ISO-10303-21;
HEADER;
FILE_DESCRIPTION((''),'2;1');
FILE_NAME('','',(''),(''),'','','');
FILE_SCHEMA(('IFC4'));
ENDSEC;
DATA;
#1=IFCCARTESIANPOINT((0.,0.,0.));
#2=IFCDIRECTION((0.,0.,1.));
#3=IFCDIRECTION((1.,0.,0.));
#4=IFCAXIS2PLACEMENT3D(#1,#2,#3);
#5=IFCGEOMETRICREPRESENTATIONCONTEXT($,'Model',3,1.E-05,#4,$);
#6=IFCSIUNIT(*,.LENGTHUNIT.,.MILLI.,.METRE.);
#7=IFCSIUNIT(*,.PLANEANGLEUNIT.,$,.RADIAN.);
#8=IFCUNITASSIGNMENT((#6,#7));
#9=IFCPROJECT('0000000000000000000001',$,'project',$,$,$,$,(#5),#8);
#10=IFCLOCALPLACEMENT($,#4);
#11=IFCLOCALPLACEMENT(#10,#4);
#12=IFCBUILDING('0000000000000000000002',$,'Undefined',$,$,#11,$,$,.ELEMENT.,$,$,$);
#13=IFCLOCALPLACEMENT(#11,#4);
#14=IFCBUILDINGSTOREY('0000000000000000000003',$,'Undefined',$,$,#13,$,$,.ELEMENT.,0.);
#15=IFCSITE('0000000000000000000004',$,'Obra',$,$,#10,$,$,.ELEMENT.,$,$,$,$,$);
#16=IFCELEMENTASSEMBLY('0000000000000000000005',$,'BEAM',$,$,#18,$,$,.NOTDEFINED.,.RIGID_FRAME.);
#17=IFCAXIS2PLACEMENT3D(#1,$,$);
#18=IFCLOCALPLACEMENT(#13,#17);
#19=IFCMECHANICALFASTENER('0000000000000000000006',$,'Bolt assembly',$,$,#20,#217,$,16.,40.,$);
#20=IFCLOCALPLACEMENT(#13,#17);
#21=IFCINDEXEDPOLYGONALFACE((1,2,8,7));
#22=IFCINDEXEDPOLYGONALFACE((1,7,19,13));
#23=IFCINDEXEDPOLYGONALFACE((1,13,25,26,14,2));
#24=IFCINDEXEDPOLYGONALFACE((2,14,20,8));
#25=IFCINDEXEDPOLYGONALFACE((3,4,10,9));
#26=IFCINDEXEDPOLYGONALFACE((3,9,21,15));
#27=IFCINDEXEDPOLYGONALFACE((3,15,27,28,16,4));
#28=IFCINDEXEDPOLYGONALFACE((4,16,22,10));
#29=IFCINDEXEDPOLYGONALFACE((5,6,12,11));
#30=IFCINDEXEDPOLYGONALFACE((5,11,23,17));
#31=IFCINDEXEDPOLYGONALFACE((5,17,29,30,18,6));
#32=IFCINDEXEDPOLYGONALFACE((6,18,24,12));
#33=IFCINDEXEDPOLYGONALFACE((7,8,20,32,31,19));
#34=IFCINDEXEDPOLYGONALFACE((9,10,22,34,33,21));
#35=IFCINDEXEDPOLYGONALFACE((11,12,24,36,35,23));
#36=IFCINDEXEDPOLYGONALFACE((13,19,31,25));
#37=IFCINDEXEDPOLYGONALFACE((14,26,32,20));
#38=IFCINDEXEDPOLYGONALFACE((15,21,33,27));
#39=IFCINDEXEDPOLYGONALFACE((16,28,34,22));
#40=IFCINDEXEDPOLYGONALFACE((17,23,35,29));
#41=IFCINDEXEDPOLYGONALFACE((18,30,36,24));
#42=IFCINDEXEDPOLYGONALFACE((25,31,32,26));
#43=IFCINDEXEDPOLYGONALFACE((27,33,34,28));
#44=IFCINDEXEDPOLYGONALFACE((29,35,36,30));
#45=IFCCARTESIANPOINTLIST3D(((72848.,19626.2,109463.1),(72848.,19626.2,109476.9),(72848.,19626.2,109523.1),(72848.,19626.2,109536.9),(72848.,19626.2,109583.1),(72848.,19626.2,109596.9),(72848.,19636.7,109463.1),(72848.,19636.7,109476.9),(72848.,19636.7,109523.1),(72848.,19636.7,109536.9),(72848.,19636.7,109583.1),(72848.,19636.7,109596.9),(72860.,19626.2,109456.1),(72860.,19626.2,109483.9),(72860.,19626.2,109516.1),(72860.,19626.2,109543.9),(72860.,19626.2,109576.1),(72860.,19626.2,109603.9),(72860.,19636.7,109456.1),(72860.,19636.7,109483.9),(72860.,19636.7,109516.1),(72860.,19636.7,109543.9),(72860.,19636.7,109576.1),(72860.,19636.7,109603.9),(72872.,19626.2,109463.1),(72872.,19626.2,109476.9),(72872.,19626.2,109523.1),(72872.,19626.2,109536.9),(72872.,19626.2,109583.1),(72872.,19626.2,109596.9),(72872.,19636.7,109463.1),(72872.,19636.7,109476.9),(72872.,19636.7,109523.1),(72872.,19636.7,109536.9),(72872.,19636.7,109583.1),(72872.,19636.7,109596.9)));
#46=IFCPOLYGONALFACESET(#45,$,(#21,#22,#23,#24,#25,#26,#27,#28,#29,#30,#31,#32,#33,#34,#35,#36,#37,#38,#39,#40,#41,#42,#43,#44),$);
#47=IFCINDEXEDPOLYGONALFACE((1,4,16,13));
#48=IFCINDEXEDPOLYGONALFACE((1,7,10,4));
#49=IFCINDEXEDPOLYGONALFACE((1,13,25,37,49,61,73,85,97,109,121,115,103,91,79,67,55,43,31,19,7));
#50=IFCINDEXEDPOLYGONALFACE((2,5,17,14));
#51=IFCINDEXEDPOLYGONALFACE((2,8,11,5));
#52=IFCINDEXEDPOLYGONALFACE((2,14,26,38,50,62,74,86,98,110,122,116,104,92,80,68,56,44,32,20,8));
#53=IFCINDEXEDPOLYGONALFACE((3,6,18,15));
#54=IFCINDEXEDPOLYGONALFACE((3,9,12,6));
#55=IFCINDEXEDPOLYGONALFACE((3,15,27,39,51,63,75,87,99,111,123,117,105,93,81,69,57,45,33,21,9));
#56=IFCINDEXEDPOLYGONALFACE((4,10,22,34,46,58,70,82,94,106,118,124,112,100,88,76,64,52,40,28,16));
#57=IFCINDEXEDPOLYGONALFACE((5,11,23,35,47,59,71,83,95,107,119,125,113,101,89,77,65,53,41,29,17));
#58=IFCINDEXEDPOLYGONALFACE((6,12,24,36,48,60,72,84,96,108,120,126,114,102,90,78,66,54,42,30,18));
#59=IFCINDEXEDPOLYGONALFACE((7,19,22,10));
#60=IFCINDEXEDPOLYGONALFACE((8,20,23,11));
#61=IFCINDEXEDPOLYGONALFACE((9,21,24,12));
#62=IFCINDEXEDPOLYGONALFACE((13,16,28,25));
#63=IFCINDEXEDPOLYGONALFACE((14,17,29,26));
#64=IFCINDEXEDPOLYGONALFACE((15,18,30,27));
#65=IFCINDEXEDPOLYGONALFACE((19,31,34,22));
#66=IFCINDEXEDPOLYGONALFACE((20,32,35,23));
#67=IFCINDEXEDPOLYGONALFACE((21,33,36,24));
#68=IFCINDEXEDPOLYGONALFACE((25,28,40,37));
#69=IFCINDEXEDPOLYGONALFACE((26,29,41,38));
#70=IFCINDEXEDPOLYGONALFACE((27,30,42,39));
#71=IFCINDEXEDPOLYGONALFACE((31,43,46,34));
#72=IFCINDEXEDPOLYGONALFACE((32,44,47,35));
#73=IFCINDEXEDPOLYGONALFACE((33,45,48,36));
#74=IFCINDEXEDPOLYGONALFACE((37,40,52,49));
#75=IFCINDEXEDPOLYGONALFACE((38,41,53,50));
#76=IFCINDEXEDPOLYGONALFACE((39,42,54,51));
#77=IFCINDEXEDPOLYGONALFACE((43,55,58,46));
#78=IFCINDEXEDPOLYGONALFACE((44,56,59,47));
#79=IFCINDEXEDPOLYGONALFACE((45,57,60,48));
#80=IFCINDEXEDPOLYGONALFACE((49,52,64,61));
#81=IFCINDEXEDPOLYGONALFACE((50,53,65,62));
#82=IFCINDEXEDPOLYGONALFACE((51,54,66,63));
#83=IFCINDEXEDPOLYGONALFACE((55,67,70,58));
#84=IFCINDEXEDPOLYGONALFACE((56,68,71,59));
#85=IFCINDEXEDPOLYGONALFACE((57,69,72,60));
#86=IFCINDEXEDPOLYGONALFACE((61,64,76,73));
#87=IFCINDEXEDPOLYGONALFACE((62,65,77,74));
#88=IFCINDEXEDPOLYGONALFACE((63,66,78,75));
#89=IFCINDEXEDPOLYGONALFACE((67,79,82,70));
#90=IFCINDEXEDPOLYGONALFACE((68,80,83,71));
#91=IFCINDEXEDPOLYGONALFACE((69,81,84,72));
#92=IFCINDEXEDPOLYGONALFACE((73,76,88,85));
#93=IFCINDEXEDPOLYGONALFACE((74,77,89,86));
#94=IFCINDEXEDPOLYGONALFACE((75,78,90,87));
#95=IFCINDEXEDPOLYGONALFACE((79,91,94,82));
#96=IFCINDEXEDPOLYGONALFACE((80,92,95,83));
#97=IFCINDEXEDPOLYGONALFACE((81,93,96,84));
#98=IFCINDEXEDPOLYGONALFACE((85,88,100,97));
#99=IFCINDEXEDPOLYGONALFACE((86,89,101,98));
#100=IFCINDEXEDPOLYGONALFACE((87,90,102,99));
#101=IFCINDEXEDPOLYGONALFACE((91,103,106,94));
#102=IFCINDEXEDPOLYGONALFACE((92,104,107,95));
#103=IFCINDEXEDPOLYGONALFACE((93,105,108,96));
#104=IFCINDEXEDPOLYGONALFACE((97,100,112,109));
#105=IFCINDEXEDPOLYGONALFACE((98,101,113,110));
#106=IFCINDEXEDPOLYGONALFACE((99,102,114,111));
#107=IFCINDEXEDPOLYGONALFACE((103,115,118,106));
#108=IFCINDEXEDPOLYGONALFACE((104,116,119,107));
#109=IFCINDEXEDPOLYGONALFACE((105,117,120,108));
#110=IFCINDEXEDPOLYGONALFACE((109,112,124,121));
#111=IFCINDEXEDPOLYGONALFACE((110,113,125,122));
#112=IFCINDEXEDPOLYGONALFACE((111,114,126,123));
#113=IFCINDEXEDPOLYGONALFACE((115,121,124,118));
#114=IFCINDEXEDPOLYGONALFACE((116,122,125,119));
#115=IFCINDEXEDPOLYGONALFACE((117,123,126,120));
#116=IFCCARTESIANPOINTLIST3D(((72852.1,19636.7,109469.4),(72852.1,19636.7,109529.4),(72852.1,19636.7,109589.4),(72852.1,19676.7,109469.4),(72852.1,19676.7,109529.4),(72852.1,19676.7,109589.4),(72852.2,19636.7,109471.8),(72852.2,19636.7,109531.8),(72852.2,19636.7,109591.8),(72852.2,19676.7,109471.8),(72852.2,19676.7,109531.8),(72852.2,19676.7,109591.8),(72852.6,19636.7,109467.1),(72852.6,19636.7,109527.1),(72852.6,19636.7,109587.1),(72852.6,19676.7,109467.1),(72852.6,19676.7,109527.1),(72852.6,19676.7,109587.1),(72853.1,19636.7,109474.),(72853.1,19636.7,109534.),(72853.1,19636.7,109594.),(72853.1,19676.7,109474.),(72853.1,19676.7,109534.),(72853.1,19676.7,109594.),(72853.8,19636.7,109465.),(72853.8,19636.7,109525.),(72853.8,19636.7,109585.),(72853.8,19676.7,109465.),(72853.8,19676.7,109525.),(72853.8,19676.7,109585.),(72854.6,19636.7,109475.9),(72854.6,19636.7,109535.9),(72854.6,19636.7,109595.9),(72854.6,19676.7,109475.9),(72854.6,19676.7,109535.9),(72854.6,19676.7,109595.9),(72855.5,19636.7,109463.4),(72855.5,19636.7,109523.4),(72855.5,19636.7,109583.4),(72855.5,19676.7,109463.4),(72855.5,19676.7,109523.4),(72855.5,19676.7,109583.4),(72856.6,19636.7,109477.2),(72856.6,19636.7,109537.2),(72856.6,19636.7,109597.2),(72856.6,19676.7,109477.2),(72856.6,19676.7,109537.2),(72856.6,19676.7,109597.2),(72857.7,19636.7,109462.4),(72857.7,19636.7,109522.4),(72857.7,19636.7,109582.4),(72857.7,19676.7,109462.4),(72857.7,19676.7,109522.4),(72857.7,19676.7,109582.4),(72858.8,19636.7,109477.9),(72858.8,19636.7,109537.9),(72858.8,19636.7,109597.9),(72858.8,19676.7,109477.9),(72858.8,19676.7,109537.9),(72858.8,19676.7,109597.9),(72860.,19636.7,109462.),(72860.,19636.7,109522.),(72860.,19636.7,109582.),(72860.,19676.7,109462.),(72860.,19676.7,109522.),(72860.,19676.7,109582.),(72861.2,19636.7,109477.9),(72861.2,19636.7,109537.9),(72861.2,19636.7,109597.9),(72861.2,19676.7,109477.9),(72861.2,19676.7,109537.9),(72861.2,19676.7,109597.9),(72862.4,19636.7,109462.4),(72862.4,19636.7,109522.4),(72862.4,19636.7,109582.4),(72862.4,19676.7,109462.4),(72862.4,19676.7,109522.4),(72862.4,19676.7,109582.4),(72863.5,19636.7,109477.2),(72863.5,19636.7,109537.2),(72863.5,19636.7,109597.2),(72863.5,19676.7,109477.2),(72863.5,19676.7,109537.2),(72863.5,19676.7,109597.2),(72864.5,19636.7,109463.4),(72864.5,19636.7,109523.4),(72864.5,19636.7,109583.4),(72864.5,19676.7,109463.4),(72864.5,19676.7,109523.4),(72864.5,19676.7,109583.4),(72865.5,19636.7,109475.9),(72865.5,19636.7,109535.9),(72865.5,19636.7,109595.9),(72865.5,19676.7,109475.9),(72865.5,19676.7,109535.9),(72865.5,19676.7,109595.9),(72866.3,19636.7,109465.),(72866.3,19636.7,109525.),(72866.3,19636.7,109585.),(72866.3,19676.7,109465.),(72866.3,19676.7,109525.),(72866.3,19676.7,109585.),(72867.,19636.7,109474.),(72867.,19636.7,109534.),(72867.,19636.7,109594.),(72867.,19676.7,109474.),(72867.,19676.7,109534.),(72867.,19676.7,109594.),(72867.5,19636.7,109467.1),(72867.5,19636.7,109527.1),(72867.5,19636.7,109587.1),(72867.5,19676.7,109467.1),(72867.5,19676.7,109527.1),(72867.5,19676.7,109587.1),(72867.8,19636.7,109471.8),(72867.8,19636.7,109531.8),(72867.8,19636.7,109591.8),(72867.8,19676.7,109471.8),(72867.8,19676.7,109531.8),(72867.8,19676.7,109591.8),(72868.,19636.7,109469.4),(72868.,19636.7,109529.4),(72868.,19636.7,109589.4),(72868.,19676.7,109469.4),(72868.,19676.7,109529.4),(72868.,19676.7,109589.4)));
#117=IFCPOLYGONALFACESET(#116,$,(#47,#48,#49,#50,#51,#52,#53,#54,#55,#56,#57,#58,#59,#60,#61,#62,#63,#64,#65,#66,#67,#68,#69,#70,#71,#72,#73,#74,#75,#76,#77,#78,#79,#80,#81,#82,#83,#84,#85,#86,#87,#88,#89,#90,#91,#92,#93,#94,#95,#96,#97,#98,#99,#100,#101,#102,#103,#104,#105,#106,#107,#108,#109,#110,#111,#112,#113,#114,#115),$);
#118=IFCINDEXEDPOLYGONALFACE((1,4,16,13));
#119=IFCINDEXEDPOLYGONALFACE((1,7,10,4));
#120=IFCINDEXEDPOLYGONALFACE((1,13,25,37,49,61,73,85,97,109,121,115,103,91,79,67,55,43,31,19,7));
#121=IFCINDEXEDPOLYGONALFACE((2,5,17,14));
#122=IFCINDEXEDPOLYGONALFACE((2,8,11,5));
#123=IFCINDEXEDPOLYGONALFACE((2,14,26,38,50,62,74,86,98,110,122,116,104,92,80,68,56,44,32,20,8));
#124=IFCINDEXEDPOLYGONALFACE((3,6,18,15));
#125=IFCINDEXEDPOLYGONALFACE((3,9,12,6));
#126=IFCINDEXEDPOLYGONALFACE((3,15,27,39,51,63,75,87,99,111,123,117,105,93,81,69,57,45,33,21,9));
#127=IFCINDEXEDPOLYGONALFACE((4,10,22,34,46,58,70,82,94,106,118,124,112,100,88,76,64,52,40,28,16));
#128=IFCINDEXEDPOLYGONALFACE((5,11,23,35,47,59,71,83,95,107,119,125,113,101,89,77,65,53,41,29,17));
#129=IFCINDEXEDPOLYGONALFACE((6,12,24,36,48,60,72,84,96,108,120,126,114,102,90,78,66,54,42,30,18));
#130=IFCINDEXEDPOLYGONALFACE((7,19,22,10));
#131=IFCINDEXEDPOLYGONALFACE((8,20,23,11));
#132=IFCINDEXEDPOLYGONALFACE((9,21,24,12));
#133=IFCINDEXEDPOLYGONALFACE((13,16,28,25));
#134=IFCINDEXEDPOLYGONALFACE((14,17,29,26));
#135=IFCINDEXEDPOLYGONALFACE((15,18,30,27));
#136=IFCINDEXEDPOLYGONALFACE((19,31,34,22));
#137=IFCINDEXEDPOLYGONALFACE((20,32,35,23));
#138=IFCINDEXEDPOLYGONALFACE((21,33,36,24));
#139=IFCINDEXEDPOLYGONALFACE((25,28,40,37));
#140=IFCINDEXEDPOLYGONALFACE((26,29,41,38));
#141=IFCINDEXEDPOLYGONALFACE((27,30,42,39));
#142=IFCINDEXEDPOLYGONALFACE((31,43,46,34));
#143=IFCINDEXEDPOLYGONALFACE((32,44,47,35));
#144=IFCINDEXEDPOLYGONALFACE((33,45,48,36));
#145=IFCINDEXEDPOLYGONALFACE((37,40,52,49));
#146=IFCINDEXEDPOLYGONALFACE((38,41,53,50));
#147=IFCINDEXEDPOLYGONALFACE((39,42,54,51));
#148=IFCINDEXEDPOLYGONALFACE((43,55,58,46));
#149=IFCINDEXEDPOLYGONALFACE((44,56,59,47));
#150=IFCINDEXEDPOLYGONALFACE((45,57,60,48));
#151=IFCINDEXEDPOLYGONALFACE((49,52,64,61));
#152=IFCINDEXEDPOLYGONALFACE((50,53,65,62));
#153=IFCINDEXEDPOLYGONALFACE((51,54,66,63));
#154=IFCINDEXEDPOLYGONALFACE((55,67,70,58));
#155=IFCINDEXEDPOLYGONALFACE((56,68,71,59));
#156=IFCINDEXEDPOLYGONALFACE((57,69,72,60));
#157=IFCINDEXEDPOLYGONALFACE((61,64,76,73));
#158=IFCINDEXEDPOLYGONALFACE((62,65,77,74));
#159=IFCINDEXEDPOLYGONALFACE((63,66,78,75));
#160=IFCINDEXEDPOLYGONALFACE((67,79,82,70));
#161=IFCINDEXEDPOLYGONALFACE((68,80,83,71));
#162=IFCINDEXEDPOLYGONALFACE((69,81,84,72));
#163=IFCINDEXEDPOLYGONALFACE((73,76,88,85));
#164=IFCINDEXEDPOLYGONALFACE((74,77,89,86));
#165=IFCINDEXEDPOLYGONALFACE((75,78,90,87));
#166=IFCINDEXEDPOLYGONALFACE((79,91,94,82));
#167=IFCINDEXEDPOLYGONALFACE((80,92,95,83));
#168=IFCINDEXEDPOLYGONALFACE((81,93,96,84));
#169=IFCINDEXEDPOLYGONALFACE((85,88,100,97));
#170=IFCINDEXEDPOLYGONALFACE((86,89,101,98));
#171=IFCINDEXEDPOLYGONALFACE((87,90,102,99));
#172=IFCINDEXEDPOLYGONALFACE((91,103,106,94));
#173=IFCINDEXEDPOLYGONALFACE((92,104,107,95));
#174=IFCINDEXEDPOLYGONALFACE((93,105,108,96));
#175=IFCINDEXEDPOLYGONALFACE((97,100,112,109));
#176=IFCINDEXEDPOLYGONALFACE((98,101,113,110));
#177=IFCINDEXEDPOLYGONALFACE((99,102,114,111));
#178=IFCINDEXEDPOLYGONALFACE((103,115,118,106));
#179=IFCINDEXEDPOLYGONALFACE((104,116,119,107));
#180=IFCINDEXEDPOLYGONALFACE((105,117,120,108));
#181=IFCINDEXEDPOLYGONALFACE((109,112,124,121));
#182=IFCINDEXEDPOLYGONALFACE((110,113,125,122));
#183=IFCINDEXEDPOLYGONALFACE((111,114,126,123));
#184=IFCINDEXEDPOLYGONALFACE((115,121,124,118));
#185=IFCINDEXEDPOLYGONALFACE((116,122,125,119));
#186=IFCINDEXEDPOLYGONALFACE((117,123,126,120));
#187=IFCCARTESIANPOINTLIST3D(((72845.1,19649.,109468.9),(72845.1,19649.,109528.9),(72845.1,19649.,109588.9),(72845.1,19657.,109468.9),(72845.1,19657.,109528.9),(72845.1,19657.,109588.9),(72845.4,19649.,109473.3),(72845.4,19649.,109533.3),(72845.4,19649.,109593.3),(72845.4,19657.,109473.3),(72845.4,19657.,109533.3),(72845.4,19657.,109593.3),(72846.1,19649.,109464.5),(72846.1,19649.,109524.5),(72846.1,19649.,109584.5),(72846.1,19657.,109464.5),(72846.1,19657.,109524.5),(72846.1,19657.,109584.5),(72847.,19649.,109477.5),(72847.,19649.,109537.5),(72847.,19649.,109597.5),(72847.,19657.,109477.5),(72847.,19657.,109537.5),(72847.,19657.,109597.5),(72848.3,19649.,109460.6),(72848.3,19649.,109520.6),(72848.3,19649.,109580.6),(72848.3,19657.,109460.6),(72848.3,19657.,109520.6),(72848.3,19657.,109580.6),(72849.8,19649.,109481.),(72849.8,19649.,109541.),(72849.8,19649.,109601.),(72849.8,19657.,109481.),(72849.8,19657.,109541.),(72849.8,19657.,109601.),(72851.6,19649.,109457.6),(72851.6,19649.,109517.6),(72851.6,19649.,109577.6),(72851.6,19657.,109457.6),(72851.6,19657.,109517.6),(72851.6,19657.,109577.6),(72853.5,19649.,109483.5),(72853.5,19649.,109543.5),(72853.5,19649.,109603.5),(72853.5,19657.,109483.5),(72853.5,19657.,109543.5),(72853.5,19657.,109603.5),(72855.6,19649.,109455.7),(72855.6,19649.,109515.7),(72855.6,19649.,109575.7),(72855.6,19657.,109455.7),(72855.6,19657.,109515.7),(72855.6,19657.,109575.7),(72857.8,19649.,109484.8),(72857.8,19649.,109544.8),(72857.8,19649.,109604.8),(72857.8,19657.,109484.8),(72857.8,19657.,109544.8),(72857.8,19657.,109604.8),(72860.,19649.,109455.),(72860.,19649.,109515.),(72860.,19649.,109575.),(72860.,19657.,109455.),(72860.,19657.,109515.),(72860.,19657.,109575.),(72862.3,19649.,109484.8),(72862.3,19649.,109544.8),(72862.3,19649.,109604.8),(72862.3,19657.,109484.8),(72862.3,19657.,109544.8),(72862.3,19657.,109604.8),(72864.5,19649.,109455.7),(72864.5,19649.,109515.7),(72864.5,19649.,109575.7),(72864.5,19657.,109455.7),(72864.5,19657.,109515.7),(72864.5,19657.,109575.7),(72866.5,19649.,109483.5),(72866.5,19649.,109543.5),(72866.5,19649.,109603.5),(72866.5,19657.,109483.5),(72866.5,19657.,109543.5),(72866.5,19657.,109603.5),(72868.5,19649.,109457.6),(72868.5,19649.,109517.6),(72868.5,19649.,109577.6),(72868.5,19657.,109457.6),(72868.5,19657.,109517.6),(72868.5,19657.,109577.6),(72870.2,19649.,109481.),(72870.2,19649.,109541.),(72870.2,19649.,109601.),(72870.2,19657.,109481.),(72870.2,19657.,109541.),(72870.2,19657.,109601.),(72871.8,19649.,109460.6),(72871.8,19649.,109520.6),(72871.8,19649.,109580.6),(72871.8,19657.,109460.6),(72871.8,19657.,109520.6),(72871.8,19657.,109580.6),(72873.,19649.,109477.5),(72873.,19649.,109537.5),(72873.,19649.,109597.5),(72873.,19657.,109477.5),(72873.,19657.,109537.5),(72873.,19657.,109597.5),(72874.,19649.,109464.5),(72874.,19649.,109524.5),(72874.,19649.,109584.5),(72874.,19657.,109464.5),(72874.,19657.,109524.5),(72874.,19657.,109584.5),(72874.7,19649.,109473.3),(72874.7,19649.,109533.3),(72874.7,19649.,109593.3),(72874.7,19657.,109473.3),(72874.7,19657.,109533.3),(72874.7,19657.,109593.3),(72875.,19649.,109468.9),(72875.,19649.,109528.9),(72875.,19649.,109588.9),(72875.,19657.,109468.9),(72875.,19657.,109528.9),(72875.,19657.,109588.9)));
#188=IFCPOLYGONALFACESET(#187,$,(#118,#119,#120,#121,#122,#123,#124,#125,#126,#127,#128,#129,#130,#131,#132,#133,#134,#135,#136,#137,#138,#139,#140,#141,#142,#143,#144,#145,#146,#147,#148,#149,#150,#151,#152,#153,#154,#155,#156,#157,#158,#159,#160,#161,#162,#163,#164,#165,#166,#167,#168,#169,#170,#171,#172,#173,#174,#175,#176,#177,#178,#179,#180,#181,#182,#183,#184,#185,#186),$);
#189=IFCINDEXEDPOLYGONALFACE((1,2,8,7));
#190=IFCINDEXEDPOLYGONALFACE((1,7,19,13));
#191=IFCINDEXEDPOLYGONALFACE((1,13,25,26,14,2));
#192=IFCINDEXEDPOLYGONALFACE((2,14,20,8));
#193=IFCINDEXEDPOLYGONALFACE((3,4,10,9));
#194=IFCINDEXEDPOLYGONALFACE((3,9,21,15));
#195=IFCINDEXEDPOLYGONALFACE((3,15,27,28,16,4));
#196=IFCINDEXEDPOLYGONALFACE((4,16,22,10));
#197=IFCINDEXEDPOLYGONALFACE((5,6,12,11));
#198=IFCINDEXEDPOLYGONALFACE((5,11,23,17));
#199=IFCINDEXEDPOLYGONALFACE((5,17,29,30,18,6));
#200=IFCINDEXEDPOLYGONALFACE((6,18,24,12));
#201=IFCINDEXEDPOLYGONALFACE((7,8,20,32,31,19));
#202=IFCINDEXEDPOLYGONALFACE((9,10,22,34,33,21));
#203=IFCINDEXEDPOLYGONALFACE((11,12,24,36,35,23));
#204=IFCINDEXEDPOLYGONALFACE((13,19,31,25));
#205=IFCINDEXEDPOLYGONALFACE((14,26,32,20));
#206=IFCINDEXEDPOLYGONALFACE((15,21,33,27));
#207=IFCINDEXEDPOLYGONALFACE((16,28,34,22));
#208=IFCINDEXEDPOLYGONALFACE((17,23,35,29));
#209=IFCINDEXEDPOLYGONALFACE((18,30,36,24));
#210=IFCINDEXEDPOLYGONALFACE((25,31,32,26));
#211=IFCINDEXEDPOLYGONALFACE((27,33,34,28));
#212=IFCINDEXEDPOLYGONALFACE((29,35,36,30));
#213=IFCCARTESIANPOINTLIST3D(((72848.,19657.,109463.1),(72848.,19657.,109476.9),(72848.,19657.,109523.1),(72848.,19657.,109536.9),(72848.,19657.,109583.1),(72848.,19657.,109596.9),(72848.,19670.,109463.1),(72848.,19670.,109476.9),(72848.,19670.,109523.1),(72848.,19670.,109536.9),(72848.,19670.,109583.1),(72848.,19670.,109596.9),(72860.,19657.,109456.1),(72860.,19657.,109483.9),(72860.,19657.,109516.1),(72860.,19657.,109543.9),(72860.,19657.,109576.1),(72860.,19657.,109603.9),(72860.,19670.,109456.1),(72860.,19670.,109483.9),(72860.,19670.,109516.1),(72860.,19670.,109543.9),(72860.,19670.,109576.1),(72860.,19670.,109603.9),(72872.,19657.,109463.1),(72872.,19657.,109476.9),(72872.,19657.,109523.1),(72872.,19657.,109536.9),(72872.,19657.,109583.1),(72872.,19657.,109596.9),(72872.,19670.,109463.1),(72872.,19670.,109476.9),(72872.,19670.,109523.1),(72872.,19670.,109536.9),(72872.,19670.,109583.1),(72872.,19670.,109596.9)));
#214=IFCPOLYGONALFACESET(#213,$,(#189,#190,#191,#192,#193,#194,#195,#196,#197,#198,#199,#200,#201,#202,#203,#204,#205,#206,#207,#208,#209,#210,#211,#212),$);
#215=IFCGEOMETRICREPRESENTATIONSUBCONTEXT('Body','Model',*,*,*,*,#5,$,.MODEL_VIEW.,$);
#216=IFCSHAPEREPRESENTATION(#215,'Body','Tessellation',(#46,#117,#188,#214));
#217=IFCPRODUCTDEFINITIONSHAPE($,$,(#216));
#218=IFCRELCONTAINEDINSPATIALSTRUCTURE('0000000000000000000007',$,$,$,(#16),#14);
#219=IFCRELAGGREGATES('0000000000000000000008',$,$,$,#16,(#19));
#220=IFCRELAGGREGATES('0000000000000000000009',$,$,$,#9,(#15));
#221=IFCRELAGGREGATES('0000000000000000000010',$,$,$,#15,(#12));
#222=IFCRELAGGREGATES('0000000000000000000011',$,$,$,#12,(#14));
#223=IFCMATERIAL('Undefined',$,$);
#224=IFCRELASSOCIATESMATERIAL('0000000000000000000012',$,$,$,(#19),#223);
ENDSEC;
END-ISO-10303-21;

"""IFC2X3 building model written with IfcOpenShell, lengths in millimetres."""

from ifc_helpers import new_model, si_unit, frame, origin_with_axes, origin_2d_with_axis, place, context, subcontext, project, spatial, polyline, circle, outline, extrude, source, transform, mapped, material, element, aggregate, save


model = new_model("IFC2X3")

# Units and contexts
model_context = context("Model", 3, precision=1e-05, world=origin_with_axes())
body_context = subcontext(model_context, "Body", "Model", "MODEL_VIEW")
ifc_project = project(units=[si_unit("LENGTHUNIT", "METRE", prefix="MILLI"), si_unit("PLANEANGLEUNIT", "RADIAN")], contexts=[model_context])

# Site, building, storey
site_placement = place(None, origin_with_axes())
site = spatial("IfcSite", under=ifc_project, at=site_placement, Name="Obra", CompositionType="ELEMENT")
building_placement = place(site_placement, origin_with_axes())
building = spatial("IfcBuilding", under=site, at=building_placement, Name="Undefined", CompositionType="ELEMENT")
storey_placement = place(building_placement, origin_with_axes())
storey = spatial("IfcBuildingStorey", under=building, at=storey_placement, Name="Undefined", CompositionType="ELEMENT", Elevation=0.0)

# Element assembly
assembly_1_placement = place(storey_placement, origin_with_axes())
assembly_1 = element("IfcElementAssembly", 1, at=assembly_1_placement, inside=storey, Name="BEAM", AssemblyPlace="NOTDEFINED", PredefinedType="RIGID_FRAME")

# Mechanical fastener
ifc_material_1 = material(Name="Undefined")
shared_shape_1 = source(origin_with_axes(), body_context, "Body", "SweptSolid", [
    extrude(outline(polyline([(13.9, 0.0), (6.9, 12.0), (-6.9, 12.0), (-13.9, 0.0), (-6.9, -12.0), (6.9, -12.0), (13.9, 0.0)])), frame((0.0, -19.7, 0.0), z_axis=(0.0, 1.0, 0.0), x_axis=(1.0, 0.0, 0.0)), (0.0, 0.0, 1.0), 10.6),
    extrude(circle(Radius=8.0, at=origin_2d_with_axis()), frame((0.0, -9.1, 0.0), z_axis=(0.0, 1.0, 0.0), x_axis=(1.0, 0.0, 0.0)), (0.0, 0.0, 1.0), 40.0),
    extrude(circle(Radius=15.0, at=origin_2d_with_axis()), frame((0.0, 3.1, 0.0), z_axis=(0.0, 1.0, 0.0), x_axis=(1.0, 0.0, 0.0)), (0.0, 0.0, 1.0), 8.0),
    extrude(outline(polyline([(13.9, 0.0), (6.9, 12.0), (-6.9, 12.0), (-13.9, 0.0), (-6.9, -12.0), (6.9, -12.0), (13.9, 0.0)])), frame((0.0, 11.1, 0.0), z_axis=(0.0, 1.0, 0.0), x_axis=(1.0, 0.0, 0.0)), (0.0, 0.0, 1.0), 13.0),
])
mechanical_fastener_1_placement = place(assembly_1_placement, frame((72810.0, 19645.8, 109650.0), z_axis=(1.0, -0.000126, 0.0), x_axis=(0.0, 0.0, -1.0)))
mechanical_fastener_1 = element("IfcMechanicalFastener", 2, at=mechanical_fastener_1_placement, material=ifc_material_1, Name="Bolt assembly", NominalDiameter=16.0, NominalLength=40.0, context=body_context, shape_type="MappedRepresentation", body=[
    mapped(shared_shape_1, transform((60.0, 0.0, 50.0))),
    mapped(shared_shape_1, transform((120.0, 0.0, 50.0))),
    mapped(shared_shape_1, transform((180.0, 0.0, 50.0))),
])
aggregate(assembly_1, [mechanical_fastener_1])

save(model, "model.ifc")
